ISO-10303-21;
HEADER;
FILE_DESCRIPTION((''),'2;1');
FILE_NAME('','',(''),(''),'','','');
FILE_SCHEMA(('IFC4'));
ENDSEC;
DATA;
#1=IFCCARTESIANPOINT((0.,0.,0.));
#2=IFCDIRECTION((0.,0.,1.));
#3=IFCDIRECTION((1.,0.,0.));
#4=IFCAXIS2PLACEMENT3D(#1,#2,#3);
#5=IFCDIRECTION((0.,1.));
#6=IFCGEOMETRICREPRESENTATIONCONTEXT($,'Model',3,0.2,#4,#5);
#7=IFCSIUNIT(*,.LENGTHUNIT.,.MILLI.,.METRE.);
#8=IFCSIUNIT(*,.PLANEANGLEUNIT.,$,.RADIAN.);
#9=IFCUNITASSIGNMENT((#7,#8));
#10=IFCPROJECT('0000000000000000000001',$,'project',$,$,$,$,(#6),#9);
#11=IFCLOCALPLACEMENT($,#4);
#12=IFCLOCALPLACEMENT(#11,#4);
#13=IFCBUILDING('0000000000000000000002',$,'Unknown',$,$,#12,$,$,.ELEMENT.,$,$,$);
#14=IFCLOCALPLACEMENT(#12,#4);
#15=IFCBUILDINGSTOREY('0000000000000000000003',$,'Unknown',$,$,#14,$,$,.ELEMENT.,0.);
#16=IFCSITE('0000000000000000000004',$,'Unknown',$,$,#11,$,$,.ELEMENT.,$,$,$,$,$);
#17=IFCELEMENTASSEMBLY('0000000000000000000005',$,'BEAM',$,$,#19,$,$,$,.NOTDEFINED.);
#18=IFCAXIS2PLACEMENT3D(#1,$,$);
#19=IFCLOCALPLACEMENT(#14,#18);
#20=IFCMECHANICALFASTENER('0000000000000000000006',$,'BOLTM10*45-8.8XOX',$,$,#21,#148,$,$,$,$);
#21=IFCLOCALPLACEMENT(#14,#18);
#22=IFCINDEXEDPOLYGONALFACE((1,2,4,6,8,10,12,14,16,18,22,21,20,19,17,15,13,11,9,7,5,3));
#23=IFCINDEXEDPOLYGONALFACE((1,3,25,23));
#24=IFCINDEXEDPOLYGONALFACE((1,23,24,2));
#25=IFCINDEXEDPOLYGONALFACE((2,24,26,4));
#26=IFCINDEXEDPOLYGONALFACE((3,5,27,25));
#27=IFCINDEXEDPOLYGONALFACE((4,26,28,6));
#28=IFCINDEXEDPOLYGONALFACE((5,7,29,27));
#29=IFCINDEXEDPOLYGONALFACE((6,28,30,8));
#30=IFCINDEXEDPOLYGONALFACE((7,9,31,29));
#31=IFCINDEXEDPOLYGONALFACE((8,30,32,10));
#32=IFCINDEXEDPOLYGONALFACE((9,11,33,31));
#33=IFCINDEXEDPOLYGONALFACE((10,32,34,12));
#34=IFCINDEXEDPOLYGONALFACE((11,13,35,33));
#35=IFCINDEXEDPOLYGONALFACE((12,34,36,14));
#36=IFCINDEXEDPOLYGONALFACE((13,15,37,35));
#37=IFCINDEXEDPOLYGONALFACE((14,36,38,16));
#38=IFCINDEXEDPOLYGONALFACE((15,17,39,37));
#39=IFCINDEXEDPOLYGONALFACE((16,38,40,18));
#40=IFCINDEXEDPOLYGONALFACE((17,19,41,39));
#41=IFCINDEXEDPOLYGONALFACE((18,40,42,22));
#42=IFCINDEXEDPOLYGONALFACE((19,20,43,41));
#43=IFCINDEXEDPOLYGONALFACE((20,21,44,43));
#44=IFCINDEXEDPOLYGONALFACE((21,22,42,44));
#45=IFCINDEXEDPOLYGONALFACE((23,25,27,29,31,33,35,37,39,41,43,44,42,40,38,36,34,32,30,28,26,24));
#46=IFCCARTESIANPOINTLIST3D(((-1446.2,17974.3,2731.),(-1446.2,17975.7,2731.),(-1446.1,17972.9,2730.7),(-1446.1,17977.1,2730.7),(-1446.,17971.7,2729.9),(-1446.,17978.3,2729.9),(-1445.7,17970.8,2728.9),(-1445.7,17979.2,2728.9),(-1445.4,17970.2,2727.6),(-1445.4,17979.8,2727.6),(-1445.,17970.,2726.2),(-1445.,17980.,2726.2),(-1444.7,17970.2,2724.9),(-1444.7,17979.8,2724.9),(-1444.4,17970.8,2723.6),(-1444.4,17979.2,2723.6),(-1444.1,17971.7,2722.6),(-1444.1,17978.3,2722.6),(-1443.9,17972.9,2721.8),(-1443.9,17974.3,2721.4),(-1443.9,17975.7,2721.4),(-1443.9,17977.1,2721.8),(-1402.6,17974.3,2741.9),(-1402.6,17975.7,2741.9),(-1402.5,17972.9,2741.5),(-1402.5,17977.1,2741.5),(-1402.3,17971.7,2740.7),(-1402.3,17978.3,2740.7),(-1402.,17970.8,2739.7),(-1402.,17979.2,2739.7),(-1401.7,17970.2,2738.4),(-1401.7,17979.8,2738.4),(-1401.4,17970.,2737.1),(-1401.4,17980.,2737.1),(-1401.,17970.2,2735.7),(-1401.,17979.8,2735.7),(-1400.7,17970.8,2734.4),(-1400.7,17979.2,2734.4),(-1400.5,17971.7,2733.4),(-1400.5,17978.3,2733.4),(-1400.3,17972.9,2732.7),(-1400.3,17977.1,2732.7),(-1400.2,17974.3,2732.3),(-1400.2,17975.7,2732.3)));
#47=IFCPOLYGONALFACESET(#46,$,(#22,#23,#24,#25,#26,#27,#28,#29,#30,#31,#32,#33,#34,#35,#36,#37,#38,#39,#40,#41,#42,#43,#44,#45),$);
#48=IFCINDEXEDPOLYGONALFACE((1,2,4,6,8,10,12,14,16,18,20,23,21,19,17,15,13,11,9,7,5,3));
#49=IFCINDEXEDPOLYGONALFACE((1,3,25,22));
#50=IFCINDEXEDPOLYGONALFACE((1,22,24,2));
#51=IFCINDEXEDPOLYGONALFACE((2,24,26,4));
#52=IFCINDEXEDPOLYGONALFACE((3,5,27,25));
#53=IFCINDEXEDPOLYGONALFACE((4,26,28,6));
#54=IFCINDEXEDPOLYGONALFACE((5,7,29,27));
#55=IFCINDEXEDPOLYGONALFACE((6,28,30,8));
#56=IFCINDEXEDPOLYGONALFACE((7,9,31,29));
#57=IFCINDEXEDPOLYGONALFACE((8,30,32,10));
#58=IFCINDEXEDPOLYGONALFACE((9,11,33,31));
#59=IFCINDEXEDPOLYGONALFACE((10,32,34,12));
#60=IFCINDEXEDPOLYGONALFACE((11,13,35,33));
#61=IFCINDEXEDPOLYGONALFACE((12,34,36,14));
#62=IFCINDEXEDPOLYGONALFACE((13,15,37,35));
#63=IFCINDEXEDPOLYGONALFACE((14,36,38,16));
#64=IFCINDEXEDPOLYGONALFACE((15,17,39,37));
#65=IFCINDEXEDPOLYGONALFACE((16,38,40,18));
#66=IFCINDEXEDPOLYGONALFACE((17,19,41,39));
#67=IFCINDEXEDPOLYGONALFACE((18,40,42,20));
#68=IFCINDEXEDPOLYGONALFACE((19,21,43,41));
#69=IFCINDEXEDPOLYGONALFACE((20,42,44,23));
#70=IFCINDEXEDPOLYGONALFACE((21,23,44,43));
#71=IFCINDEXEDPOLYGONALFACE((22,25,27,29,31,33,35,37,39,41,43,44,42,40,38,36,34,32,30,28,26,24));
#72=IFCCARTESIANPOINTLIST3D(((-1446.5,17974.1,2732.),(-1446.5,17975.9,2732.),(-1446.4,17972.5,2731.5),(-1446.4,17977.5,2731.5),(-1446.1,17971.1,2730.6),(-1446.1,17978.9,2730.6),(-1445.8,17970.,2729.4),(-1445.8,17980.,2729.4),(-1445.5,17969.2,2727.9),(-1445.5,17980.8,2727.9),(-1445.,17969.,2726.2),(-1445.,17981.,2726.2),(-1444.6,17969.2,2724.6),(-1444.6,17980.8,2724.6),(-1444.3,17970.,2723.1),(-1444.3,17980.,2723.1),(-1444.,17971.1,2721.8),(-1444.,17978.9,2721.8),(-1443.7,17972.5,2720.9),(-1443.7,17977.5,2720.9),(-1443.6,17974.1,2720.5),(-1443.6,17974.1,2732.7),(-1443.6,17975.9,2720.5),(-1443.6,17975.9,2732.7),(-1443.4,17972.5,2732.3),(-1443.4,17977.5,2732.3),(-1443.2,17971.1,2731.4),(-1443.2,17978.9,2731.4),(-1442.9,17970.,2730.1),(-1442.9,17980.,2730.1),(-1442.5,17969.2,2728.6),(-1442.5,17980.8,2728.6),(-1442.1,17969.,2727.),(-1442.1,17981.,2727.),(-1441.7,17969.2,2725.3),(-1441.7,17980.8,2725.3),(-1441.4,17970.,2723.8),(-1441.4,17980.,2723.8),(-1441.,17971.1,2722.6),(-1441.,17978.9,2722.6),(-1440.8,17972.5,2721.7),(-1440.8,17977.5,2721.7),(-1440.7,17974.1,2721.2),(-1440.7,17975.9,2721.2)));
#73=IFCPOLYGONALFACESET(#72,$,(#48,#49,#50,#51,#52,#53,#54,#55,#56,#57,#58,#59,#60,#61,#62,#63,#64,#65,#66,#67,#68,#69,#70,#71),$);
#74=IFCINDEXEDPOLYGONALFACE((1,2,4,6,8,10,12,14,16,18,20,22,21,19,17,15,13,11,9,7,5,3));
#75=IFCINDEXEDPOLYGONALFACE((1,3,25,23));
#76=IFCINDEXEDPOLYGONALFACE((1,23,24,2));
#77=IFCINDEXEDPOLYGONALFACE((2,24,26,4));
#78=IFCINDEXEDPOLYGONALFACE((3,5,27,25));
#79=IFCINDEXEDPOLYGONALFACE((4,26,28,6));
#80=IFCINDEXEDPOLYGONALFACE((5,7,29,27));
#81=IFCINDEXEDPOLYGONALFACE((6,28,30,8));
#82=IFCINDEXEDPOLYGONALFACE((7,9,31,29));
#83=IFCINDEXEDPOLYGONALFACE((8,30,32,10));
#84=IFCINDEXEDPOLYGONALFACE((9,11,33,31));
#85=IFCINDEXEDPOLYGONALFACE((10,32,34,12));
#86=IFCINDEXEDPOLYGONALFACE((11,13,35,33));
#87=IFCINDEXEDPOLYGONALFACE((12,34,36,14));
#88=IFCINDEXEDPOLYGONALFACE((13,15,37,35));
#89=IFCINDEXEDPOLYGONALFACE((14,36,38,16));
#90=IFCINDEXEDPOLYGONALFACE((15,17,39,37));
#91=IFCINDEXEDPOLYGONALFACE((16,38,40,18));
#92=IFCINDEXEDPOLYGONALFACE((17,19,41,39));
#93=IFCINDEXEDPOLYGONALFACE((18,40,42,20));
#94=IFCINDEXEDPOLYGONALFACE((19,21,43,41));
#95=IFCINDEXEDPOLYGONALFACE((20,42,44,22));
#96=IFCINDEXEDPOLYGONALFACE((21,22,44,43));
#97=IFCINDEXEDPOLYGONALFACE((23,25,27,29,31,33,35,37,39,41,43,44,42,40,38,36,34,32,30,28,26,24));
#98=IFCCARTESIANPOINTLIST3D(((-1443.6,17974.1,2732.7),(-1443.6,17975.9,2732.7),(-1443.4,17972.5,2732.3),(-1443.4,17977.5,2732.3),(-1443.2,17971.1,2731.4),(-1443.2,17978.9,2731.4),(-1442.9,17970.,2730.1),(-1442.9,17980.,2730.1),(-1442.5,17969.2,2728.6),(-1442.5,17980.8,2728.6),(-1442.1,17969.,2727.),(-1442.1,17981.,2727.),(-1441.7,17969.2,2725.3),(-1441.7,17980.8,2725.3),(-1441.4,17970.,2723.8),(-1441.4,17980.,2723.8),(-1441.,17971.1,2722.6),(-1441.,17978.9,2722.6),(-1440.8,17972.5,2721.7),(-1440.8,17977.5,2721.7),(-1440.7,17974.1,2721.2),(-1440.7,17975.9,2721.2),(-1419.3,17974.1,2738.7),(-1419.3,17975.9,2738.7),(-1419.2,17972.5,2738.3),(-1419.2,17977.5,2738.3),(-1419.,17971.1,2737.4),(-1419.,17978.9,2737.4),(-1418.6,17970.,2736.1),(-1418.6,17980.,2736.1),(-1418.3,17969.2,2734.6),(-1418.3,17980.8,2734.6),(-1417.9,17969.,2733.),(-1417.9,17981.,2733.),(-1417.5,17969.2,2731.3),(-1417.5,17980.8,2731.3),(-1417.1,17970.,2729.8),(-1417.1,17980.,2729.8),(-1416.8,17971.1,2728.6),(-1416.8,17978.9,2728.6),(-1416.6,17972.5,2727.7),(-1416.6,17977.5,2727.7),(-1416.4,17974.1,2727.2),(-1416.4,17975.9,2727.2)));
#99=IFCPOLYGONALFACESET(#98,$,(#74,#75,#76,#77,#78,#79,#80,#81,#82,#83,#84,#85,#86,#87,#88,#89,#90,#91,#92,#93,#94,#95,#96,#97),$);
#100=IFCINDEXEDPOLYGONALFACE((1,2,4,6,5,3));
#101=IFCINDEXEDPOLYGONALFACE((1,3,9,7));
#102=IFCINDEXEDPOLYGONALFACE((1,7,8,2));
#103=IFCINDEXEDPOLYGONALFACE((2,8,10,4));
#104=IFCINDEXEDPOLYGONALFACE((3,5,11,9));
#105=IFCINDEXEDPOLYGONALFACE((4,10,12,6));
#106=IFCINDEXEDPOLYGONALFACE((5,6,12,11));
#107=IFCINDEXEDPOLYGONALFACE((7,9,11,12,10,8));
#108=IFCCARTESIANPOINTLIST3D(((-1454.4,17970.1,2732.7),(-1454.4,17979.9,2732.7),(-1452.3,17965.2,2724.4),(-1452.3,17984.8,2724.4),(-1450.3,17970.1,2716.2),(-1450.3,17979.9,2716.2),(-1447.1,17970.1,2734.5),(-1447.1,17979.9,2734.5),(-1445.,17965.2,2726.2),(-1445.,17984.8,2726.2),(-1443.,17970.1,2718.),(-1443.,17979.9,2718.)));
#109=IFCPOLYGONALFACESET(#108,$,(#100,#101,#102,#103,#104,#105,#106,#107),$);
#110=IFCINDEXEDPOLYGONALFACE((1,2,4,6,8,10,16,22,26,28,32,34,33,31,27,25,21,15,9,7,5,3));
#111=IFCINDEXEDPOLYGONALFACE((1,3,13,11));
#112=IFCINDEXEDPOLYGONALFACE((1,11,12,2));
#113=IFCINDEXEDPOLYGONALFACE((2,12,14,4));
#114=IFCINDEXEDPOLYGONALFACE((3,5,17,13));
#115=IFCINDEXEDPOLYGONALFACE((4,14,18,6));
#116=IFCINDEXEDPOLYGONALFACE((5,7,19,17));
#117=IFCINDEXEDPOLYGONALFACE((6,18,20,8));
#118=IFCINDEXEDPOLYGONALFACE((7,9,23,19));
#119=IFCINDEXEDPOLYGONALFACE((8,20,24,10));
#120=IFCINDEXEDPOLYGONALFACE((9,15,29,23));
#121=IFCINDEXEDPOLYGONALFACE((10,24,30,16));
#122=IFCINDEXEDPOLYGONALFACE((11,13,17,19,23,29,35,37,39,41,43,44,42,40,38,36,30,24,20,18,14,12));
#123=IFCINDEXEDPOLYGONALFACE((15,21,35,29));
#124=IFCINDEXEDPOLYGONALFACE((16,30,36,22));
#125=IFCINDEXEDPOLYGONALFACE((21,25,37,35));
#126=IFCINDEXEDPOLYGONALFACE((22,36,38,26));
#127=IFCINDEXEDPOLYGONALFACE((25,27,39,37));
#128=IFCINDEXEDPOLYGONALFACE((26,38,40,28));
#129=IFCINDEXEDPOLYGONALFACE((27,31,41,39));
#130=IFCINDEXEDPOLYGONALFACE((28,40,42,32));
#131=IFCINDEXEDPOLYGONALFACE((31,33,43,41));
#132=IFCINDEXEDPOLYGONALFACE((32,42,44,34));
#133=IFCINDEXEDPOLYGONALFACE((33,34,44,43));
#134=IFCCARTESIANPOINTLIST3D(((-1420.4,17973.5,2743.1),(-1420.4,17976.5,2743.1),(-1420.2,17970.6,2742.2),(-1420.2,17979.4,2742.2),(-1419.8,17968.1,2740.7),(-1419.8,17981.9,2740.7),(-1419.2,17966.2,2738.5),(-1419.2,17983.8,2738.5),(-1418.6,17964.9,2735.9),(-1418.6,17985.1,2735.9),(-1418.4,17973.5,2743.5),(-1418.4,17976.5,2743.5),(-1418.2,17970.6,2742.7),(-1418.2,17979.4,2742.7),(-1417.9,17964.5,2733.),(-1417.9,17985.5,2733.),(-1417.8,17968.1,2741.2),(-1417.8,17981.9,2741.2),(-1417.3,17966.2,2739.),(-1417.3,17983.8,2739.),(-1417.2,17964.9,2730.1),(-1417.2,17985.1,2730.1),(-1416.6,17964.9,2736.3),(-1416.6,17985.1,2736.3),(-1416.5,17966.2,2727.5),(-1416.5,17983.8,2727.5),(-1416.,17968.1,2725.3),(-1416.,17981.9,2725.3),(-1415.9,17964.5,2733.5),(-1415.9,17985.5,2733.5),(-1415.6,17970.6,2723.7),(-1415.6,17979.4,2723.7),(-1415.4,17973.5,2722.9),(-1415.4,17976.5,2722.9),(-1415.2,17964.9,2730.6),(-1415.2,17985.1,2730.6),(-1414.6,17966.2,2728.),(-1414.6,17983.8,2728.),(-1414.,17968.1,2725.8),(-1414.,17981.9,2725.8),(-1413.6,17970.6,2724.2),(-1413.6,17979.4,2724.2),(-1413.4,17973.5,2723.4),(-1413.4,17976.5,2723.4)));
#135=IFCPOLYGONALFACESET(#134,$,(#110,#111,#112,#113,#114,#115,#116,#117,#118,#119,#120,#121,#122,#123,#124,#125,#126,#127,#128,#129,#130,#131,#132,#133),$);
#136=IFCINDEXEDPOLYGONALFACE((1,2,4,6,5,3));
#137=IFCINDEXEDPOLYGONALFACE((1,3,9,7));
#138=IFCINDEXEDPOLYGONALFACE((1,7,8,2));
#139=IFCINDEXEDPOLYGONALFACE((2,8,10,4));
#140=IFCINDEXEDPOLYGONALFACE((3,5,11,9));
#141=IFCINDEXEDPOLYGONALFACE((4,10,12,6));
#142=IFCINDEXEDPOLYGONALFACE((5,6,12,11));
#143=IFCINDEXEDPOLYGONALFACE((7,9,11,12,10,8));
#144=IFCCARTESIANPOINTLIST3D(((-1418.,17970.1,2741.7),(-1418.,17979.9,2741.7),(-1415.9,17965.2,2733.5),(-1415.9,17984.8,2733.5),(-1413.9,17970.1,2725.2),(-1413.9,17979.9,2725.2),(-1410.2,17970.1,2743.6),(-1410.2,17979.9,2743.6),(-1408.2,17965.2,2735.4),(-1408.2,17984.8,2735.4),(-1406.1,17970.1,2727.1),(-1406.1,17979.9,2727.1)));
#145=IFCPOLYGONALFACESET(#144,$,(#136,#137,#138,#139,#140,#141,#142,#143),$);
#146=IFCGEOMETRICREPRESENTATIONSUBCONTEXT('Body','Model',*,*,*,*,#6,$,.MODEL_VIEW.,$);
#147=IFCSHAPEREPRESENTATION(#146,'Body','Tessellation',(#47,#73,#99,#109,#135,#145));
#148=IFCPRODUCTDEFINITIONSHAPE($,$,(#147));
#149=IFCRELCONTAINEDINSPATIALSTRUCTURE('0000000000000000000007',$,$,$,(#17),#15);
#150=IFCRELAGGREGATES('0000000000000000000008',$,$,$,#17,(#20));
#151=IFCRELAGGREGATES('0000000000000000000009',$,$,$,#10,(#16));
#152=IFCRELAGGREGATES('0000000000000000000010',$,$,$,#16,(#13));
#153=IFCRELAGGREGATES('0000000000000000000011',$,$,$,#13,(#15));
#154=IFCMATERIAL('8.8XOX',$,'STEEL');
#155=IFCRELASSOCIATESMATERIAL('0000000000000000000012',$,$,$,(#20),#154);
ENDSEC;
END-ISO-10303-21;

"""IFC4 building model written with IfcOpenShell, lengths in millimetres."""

from ifc_helpers import new_model, si_unit, direction, frame, origin_with_axes, place, context, subcontext, project, spatial, line, arc, indexed_curve, outline, extrude, source, transform, mapped, material, element, aggregate, save


model = new_model("IFC4")

# Units and contexts
model_context = context("Model", 3, precision=0.2, world=origin_with_axes(), true_north=direction((0.0, 1.0)))
body_context = subcontext(model_context, "Body", "Model", "MODEL_VIEW")
ifc_project = project(units=[si_unit("LENGTHUNIT", "METRE", prefix="MILLI"), si_unit("PLANEANGLEUNIT", "RADIAN")], contexts=[model_context])

# Site, building, storey
site_placement = place(None, origin_with_axes())
site = spatial("IfcSite", under=ifc_project, at=site_placement, Name="Unknown", CompositionType="ELEMENT")
building_placement = place(site_placement, origin_with_axes())
building = spatial("IfcBuilding", under=site, at=building_placement, Name="Unknown", CompositionType="ELEMENT")
storey_placement = place(building_placement, origin_with_axes())
storey = spatial("IfcBuildingStorey", under=building, at=storey_placement, Name="Unknown", CompositionType="ELEMENT", Elevation=0.0)

# Element assembly, mechanical fastener
ifc_material_1 = material(Name="8.8XOX", Category="STEEL")
shared_shape_1 = source(origin_with_axes(), body_context, "Body", "SweptSolid", [
    extrude(outline(indexed_curve([(5.0, 0.0), (0.0, 5.0), (-5.0, 0.0), (0.0, -5.0)], segments=[arc(1, 2, 3), arc(3, 4, 1)])), frame((0.0, 0.0, 3.8), z_axis=(0.0, 0.0, -1.0), x_axis=(0.0, 1.0, 0.0)), (0.0, 0.0, 1.0), 45.0),
    extrude(outline(indexed_curve([(6.0, 0.0), (0.0, 6.0), (-6.0, 0.0), (0.0, -6.0)], segments=[arc(1, 2, 3), arc(3, 4, 1)])), frame((0.0, 0.0, 3.8), z_axis=(0.0, 0.0, -1.0), x_axis=(0.0, 1.0, 0.0)), (0.0, 0.0, 1.0), 3.0),
    extrude(outline(indexed_curve([(6.0, 0.0), (0.0, 6.0), (-6.0, 0.0), (0.0, -6.0)], segments=[arc(1, 2, 3), arc(3, 4, 1)])), frame((0.0, 0.0, 0.8), z_axis=(0.0, 0.0, -1.0), x_axis=(0.0, 1.0, 0.0)), (0.0, 0.0, 1.0), 25.0),
    extrude(outline(indexed_curve([(9.8, 0.0), (4.9, 8.5), (-4.9, 8.5), (-9.8, 0.0), (-4.9, -8.5), (4.9, -8.5)], segments=[line(1, 2, 3, 4, 5, 6, 1)])), frame((0.0, 0.0, 11.2), z_axis=(0.0, 0.0, -1.0), x_axis=(0.0, 1.0, 0.0)), (0.0, 0.0, 1.0), 7.5),
    extrude(outline(indexed_curve([(10.5, 0.0), (0.0, 10.5), (-10.5, 0.0), (0.0, -10.5)], segments=[arc(1, 2, 3), arc(3, 4, 1)])), frame((0.0, 0.0, -24.2), z_axis=(0.0, 0.0, -1.0), x_axis=(0.0, 1.0, 0.0)), (0.0, 0.0, 1.0), 2.0),
    extrude(outline(indexed_curve([(9.8, 0.0), (4.9, 8.5), (-4.9, 8.5), (-9.8, 0.0), (-4.9, -8.5), (4.9, -8.5)], segments=[line(1, 2, 3, 4, 5, 6, 1)])), frame((0.0, 0.0, -26.2), z_axis=(0.0, 0.0, -1.0), x_axis=(0.0, 1.0, 0.0)), (0.0, 0.0, 1.0), 8.0),
])
assembly_1_placement = place(storey_placement, frame((-1431.2, 12000.0, 2734.8), z_axis=(0.970613, 0.0, 0.240648), x_axis=(0.0, 1.0, 0.0)))
assembly_1 = element("IfcElementAssembly", 1, at=assembly_1_placement, inside=storey, Name="BEAM", PredefinedType="NOTDEFINED")
mechanical_fastener_1_placement = place(assembly_1_placement, frame((5975.0, -5.0, -11.8), z_axis=(0.0, 0.0, -1.0), x_axis=(0.0, 1.0, 0.0)))
mechanical_fastener_1 = element("IfcMechanicalFastener", 2, at=mechanical_fastener_1_placement, material=ifc_material_1, Name="BOLTM10*45-8.8XOX", context=body_context, shape_type="MappedRepresentation", body=[
    mapped(shared_shape_1, transform((0.0, 0.0, 0.0))),
])
aggregate(assembly_1, [mechanical_fastener_1])

save(model, "model.ifc")
